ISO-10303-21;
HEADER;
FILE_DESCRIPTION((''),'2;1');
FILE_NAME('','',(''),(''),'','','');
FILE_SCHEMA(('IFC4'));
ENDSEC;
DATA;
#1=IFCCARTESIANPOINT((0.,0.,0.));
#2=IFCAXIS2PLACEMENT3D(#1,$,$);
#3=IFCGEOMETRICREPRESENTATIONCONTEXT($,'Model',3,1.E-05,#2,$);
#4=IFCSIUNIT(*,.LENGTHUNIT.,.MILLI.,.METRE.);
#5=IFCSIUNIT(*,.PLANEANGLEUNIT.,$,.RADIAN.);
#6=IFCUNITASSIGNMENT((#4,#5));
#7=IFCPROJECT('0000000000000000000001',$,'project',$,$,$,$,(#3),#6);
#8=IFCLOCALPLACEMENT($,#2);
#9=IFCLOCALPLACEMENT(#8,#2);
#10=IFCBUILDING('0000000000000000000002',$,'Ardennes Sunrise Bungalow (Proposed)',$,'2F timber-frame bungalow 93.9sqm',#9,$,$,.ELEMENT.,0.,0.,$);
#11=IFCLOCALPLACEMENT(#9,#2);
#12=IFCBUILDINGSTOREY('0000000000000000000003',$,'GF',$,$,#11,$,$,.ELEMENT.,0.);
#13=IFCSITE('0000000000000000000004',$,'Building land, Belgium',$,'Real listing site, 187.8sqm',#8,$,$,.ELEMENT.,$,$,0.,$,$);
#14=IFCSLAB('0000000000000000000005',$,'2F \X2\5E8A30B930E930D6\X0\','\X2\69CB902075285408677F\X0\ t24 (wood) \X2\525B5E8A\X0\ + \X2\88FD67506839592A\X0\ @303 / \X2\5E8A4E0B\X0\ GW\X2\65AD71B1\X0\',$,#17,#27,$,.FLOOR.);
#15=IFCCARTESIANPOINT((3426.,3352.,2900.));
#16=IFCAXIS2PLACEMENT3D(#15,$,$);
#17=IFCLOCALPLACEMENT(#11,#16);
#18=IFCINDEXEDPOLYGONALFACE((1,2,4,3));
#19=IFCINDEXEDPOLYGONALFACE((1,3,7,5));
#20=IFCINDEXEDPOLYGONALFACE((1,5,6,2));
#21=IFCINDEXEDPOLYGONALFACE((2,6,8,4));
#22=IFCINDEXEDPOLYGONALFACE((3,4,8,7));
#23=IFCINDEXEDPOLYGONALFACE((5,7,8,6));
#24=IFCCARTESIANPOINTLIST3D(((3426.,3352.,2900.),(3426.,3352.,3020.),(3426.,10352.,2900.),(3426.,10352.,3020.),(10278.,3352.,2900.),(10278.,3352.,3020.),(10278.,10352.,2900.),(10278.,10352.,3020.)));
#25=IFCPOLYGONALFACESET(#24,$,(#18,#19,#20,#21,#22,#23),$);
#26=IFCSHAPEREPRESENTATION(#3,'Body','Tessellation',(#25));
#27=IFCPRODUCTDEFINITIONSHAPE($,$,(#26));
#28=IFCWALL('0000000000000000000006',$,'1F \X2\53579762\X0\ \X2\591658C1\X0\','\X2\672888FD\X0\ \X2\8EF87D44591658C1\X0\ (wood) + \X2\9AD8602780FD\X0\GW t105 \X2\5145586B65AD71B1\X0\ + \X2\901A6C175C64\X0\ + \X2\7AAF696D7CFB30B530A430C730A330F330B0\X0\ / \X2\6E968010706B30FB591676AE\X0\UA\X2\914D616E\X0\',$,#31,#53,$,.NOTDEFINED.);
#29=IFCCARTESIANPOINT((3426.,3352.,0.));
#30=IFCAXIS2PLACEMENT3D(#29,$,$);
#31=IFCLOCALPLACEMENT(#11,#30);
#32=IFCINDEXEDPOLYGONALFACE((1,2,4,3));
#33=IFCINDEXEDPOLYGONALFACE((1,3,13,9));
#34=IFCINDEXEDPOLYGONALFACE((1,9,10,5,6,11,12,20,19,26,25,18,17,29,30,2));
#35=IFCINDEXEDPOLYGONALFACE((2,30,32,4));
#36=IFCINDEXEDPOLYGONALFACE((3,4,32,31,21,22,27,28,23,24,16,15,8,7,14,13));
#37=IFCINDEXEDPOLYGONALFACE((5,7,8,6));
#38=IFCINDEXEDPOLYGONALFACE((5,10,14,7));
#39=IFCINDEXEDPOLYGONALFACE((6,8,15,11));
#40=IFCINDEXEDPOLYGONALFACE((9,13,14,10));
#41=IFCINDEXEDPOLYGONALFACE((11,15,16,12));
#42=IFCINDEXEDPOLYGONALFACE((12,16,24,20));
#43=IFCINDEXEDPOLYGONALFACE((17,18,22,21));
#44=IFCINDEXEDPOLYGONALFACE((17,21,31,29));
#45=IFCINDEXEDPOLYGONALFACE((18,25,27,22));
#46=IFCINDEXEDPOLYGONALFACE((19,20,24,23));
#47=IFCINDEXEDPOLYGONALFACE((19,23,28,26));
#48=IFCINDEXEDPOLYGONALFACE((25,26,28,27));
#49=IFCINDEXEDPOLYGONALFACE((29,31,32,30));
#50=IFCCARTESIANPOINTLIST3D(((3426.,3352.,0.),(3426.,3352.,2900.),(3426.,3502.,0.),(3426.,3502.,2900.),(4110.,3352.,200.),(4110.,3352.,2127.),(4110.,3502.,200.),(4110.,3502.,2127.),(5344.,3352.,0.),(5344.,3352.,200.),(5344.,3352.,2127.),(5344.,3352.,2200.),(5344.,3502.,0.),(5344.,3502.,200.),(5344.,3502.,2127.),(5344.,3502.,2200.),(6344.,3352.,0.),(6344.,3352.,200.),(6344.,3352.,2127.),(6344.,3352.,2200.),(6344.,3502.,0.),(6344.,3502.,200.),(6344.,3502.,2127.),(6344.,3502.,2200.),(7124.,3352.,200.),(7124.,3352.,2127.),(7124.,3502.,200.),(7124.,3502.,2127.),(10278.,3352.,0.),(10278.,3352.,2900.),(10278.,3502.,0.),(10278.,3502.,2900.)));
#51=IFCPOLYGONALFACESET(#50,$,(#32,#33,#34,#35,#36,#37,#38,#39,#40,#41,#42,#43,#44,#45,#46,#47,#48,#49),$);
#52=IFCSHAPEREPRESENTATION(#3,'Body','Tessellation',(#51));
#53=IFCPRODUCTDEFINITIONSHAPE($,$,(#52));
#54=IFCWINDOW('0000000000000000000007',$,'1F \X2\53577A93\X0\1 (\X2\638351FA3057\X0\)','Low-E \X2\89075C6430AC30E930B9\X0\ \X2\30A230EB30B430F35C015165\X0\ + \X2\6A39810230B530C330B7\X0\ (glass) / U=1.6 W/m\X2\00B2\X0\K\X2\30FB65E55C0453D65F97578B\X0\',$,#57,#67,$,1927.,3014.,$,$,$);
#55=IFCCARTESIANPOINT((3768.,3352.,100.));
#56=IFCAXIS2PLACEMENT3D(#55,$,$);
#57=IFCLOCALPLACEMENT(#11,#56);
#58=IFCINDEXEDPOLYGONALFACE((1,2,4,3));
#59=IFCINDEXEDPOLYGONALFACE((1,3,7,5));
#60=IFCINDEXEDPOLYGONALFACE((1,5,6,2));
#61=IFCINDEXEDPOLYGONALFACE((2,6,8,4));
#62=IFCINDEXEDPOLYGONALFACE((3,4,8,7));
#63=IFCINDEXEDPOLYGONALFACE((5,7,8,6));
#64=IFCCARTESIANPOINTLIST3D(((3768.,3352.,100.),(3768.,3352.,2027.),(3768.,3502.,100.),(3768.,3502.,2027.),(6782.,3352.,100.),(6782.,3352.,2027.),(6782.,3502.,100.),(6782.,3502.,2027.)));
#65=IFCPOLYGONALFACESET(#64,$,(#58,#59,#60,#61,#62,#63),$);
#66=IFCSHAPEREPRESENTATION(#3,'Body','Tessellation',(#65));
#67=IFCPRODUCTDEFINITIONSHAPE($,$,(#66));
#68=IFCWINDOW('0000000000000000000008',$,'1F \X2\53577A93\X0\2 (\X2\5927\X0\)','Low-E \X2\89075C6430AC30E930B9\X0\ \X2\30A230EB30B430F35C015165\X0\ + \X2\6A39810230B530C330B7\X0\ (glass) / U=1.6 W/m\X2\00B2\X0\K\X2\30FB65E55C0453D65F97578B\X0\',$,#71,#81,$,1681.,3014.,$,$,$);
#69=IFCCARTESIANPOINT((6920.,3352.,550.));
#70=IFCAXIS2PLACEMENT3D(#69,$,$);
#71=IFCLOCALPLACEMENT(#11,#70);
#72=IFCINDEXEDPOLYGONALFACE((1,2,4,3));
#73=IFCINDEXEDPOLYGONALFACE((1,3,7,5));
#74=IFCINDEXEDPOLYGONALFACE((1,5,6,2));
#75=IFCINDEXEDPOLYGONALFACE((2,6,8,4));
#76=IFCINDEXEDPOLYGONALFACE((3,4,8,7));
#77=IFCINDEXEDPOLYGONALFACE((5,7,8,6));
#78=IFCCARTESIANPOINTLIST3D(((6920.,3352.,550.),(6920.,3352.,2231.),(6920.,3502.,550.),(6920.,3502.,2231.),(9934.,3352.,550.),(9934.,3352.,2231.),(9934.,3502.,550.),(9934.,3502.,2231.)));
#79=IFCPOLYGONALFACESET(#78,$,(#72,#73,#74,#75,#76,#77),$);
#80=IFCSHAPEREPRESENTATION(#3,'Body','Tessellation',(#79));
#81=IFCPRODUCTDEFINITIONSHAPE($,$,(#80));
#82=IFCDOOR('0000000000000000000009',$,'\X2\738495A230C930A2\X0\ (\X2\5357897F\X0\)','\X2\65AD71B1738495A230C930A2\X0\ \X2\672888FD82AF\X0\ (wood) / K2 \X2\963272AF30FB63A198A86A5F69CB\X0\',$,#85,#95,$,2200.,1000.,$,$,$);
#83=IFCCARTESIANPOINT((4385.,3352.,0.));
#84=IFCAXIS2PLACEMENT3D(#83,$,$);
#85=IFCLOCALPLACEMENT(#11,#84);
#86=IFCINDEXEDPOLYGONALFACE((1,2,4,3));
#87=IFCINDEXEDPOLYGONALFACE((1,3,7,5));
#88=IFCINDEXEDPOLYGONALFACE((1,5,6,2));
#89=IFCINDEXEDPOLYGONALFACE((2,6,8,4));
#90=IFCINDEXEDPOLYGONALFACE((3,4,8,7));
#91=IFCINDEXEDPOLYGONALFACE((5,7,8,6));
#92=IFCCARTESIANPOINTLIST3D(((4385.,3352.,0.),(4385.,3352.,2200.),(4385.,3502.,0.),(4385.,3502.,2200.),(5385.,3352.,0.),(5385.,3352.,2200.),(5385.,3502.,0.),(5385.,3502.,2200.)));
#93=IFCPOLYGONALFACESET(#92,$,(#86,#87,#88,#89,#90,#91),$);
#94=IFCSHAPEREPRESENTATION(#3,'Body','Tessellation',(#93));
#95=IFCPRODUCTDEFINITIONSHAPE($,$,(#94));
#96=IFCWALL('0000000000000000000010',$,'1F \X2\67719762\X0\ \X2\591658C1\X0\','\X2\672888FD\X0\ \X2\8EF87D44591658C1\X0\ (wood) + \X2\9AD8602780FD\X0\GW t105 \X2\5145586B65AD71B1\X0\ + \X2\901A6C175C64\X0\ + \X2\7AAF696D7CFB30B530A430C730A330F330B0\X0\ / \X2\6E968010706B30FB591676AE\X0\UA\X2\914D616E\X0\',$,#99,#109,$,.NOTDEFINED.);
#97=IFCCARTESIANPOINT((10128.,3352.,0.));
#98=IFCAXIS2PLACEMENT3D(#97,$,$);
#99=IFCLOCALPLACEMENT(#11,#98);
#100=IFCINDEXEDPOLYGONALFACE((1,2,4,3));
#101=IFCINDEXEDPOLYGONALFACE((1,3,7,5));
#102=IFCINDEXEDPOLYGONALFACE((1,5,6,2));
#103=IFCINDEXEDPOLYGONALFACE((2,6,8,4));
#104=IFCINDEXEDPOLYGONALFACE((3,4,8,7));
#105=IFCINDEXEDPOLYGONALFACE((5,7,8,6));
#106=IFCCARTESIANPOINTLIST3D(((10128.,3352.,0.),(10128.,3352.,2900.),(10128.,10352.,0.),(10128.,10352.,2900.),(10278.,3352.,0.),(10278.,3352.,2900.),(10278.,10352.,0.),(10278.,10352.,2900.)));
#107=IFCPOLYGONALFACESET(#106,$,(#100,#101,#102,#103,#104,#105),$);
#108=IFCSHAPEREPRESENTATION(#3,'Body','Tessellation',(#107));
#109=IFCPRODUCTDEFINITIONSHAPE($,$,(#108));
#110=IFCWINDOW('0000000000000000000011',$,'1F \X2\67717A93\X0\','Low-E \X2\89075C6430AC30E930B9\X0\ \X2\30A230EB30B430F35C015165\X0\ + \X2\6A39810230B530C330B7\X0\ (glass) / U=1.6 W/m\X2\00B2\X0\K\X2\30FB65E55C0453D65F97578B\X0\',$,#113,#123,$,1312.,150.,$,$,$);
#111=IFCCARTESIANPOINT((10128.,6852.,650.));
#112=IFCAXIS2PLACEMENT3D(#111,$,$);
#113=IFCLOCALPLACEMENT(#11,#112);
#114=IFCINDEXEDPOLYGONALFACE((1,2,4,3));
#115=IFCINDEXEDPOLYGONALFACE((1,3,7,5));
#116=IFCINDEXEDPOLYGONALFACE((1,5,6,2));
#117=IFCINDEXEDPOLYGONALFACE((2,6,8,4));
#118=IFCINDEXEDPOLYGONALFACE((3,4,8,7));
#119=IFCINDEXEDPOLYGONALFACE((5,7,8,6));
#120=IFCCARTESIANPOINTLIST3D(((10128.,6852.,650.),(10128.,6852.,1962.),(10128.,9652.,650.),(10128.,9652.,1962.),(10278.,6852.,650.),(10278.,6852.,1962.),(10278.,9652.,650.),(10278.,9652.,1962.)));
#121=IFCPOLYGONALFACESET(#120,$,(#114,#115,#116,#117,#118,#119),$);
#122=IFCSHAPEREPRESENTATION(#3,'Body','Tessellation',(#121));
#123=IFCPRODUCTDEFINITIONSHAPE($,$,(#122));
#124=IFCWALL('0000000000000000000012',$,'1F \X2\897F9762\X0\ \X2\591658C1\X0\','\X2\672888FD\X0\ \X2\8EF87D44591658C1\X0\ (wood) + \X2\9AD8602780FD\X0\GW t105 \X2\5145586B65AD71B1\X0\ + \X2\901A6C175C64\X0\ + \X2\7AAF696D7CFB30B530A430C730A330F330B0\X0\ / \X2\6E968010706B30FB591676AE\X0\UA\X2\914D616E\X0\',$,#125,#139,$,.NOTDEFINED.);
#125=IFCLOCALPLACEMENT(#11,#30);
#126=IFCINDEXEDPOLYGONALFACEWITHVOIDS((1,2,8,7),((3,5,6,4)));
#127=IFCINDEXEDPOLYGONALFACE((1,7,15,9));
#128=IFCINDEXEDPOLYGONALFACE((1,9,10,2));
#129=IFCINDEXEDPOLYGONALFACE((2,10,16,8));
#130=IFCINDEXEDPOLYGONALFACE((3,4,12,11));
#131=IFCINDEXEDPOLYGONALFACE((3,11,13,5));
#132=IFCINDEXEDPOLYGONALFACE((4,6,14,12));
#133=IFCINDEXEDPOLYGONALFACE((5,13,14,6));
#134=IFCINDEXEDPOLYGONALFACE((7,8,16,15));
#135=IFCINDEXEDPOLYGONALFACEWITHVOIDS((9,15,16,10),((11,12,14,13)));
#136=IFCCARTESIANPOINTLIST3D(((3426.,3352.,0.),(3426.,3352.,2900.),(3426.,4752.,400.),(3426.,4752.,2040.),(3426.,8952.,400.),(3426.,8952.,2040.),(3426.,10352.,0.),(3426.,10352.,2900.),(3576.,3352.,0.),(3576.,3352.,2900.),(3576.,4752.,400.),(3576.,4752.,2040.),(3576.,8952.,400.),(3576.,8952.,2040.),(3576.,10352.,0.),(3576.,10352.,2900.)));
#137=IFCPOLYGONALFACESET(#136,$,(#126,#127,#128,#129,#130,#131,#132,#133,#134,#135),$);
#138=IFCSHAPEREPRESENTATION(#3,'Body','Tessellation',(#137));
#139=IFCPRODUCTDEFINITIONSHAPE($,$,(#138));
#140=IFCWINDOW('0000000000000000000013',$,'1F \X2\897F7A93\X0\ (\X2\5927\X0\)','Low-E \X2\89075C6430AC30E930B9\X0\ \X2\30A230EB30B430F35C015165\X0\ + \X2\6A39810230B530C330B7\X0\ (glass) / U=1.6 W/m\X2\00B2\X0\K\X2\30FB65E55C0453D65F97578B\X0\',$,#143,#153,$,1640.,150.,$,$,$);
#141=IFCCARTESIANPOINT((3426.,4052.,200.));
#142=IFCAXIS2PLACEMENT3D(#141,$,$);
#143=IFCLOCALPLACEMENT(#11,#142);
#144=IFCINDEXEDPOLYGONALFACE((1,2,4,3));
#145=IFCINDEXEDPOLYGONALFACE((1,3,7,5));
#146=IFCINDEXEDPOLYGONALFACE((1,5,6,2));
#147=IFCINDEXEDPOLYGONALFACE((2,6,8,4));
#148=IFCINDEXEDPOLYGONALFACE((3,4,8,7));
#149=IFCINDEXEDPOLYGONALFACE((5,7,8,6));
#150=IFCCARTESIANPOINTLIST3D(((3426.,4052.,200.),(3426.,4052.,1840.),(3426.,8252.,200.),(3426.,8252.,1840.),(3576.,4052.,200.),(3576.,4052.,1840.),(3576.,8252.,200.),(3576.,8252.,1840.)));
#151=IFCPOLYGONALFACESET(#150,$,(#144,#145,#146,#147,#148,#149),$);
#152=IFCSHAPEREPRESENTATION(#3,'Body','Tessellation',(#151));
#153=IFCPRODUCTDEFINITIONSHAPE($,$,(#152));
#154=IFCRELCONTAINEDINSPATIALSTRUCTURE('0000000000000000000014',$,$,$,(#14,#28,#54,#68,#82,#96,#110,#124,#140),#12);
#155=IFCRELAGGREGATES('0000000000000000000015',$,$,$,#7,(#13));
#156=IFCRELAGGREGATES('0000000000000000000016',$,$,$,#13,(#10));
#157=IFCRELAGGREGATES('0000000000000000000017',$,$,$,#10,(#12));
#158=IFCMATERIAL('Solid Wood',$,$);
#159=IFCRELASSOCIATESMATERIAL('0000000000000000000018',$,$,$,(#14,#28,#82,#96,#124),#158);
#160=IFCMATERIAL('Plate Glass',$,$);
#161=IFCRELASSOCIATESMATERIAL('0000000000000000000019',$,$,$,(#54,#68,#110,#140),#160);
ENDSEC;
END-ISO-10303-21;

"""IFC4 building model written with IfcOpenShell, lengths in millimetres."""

from ifc_helpers import new_model, si_unit, frame, frame_2d, origin, place, context, project, spatial, rectangle, extrude, material, element, fill, save


model = new_model("IFC4")

# Units and contexts
model_context = context("Model", 3, precision=1e-05, world=origin())
ifc_project = project(units=[si_unit("LENGTHUNIT", "METRE", prefix="MILLI"), si_unit("PLANEANGLEUNIT", "RADIAN")], contexts=[model_context])

# Site, building, storey
site_placement = place(None, origin())
site = spatial("IfcSite", under=ifc_project, at=site_placement, Name="Building land, Belgium", ObjectType="Real listing site, 187.8sqm", CompositionType="ELEMENT", RefElevation=0.0)
building_placement = place(site_placement, origin())
building = spatial("IfcBuilding", under=site, at=building_placement, Name="Ardennes Sunrise Bungalow (Proposed)", ObjectType="2F timber-frame bungalow 93.9sqm", CompositionType="ELEMENT", ElevationOfRefHeight=0.0, ElevationOfTerrain=0.0)
storey_placement = place(building_placement, origin())
storey = spatial("IfcBuildingStorey", under=building, at=storey_placement, Name="GF", CompositionType="ELEMENT", Elevation=0.0)

# Slab
ifc_material_1 = material(Name="Solid Wood")
slab_1_placement = place(storey_placement, frame((3426.0, 3352.0, 2900.0)))
element("IfcSlab", 1, at=slab_1_placement, inside=storey, material=ifc_material_1, Name="2F 床スラブ", Description="構造用合板 t24 (wood) 剛床 + 製材根太 @303 / 床下 GW断熱", PredefinedType="FLOOR", context=model_context, shape_type="SweptSolid", body=[
    extrude(rectangle(XDim=6852.0, YDim=7000.0, at=frame_2d((3426.0, 3500.0))), frame((3426.0, 3352.0, 2900.0)), (0.0, 0.0, 1.0), 120.0),
])

# Wall, openings, windows, door
wall_1_placement = place(storey_placement, frame((3426.0, 3352.0, 0.0)))
wall_1 = element("IfcWall", 2, at=wall_1_placement, inside=storey, material=ifc_material_1, Name="1F 南面 外壁", Description="木製 軸組外壁 (wood) + 高性能GW t105 充填断熱 + 通気層 + 窯業系サイディング / 準耐火・外皮UA配慮", PredefinedType="NOTDEFINED", context=model_context, shape_type="SweptSolid", body=[
    extrude(rectangle(XDim=6852.0, YDim=150.0, at=frame_2d((3426.0, 75.0))), frame((3426.0, 3352.0, 0.0)), (0.0, 0.0, 1.0), 2900.0),
])
opening_1_placement = place(storey_placement, frame((3768.0, 3352.0, 100.0)))
opening_1 = element("IfcOpeningElement", 3, at=opening_1_placement, cuts=wall_1, PredefinedType="NOTDEFINED", context=model_context, shape_type="SweptSolid", body=[
    extrude(rectangle(XDim=3014.0, YDim=150.0, at=frame_2d((1507.0, 75.0))), frame((3768.0, 3352.0, 100.0)), (0.0, 0.0, 1.0), 1927.0),
])
opening_2_placement = place(storey_placement, frame((6920.0, 3352.0, 550.0)))
opening_2 = element("IfcOpeningElement", 4, at=opening_2_placement, cuts=wall_1, PredefinedType="NOTDEFINED", context=model_context, shape_type="SweptSolid", body=[
    extrude(rectangle(XDim=3014.0, YDim=150.0, at=frame_2d((1507.0, 75.0))), frame((6920.0, 3352.0, 550.0)), (0.0, 0.0, 1.0), 1681.0),
])
opening_3_placement = place(storey_placement, frame((4385.0, 3352.0, 0.0)))
opening_3 = element("IfcOpeningElement", 5, at=opening_3_placement, cuts=wall_1, PredefinedType="NOTDEFINED", context=model_context, shape_type="SweptSolid", body=[
    extrude(rectangle(XDim=1000.0, YDim=150.0, at=frame_2d((500.0, 75.0))), frame((4385.0, 3352.0, 0.0)), (0.0, 0.0, 1.0), 2200.0),
])
ifc_material_2 = material(Name="Plate Glass")
window_1_placement = place(storey_placement, frame((3768.0, 3352.0, 100.0)))
window_1 = element("IfcWindow", 6, at=window_1_placement, inside=storey, material=ifc_material_2, Name="1F 南窓1 (掃出し)", Description="Low-E 複層ガラス アルゴン封入 + 樹脂サッシ (glass) / U=1.6 W/m²K・日射取得型", OverallHeight=1927.0, OverallWidth=3014.0, context=model_context, shape_type="SweptSolid", body=[
    extrude(rectangle(XDim=3014.0, YDim=150.0, at=frame_2d((1507.0, 75.0))), frame((3768.0, 3352.0, 100.0)), (0.0, 0.0, 1.0), 1927.0),
])
fill(opening_1, window_1)
window_2_placement = place(storey_placement, frame((6920.0, 3352.0, 550.0)))
window_2 = element("IfcWindow", 7, at=window_2_placement, inside=storey, material=ifc_material_2, Name="1F 南窓2 (大)", Description="Low-E 複層ガラス アルゴン封入 + 樹脂サッシ (glass) / U=1.6 W/m²K・日射取得型", OverallHeight=1681.0, OverallWidth=3014.0, context=model_context, shape_type="SweptSolid", body=[
    extrude(rectangle(XDim=3014.0, YDim=150.0, at=frame_2d((1507.0, 75.0))), frame((6920.0, 3352.0, 550.0)), (0.0, 0.0, 1.0), 1681.0),
])
fill(opening_2, window_2)
door_placement = place(storey_placement, frame((4385.0, 3352.0, 0.0)))
door = element("IfcDoor", 8, at=door_placement, inside=storey, material=ifc_material_1, Name="玄関ドア (南西)", Description="断熱玄関ドア 木製芯 (wood) / K2 防犯・採風機構", OverallHeight=2200.0, OverallWidth=1000.0, context=model_context, shape_type="SweptSolid", body=[
    extrude(rectangle(XDim=1000.0, YDim=150.0, at=frame_2d((500.0, 75.0))), frame((4385.0, 3352.0, 0.0)), (0.0, 0.0, 1.0), 2200.0),
])
fill(opening_3, door)

# Walls, openings, windows
wall_2_placement = place(storey_placement, frame((10128.0, 3352.0, 0.0)))
wall_2 = element("IfcWall", 9, at=wall_2_placement, inside=storey, material=ifc_material_1, Name="1F 東面 外壁", Description="木製 軸組外壁 (wood) + 高性能GW t105 充填断熱 + 通気層 + 窯業系サイディング / 準耐火・外皮UA配慮", PredefinedType="NOTDEFINED", context=model_context, shape_type="SweptSolid", body=[
    extrude(rectangle(XDim=150.0, YDim=7000.0, at=frame_2d((75.0, 3500.0))), frame((10128.0, 3352.0, 0.0)), (0.0, 0.0, 1.0), 2900.0),
])
opening_4_placement = place(storey_placement, frame((10128.0, 6852.0, 650.0)))
opening_4 = element("IfcOpeningElement", 10, at=opening_4_placement, cuts=wall_2, PredefinedType="NOTDEFINED", context=model_context, shape_type="SweptSolid", body=[
    extrude(rectangle(XDim=150.0, YDim=2800.0, at=frame_2d((75.0, 1400.0))), frame((10128.0, 6852.0, 650.0)), (0.0, 0.0, 1.0), 1312.0),
])
window_3_placement = place(storey_placement, frame((10128.0, 6852.0, 650.0)))
window_3 = element("IfcWindow", 11, at=window_3_placement, inside=storey, material=ifc_material_2, Name="1F 東窓", Description="Low-E 複層ガラス アルゴン封入 + 樹脂サッシ (glass) / U=1.6 W/m²K・日射取得型", OverallHeight=1312.0, OverallWidth=150.0, context=model_context, shape_type="SweptSolid", body=[
    extrude(rectangle(XDim=150.0, YDim=2800.0, at=frame_2d((75.0, 1400.0))), frame((10128.0, 6852.0, 650.0)), (0.0, 0.0, 1.0), 1312.0),
])
fill(opening_4, window_3)
wall_3_placement = place(storey_placement, frame((3426.0, 3352.0, 0.0)))
wall_3 = element("IfcWall", 12, at=wall_3_placement, inside=storey, material=ifc_material_1, Name="1F 西面 外壁", Description="木製 軸組外壁 (wood) + 高性能GW t105 充填断熱 + 通気層 + 窯業系サイディング / 準耐火・外皮UA配慮", PredefinedType="NOTDEFINED", context=model_context, shape_type="SweptSolid", body=[
    extrude(rectangle(XDim=150.0, YDim=7000.0, at=frame_2d((75.0, 3500.0))), frame((3426.0, 3352.0, 0.0)), (0.0, 0.0, 1.0), 2900.0),
])
opening_5_placement = place(storey_placement, frame((3426.0, 4052.0, 200.0)))
opening_5 = element("IfcOpeningElement", 13, at=opening_5_placement, cuts=wall_3, PredefinedType="NOTDEFINED", context=model_context, shape_type="SweptSolid", body=[
    extrude(rectangle(XDim=150.0, YDim=4200.0, at=frame_2d((75.0, 2100.0))), frame((3426.0, 4052.0, 200.0)), (0.0, 0.0, 1.0), 1640.0),
])
window_4_placement = place(storey_placement, frame((3426.0, 4052.0, 200.0)))
window_4 = element("IfcWindow", 14, at=window_4_placement, inside=storey, material=ifc_material_2, Name="1F 西窓 (大)", Description="Low-E 複層ガラス アルゴン封入 + 樹脂サッシ (glass) / U=1.6 W/m²K・日射取得型", OverallHeight=1640.0, OverallWidth=150.0, context=model_context, shape_type="SweptSolid", body=[
    extrude(rectangle(XDim=150.0, YDim=4200.0, at=frame_2d((75.0, 2100.0))), frame((3426.0, 4052.0, 200.0)), (0.0, 0.0, 1.0), 1640.0),
])
fill(opening_5, window_4)

save(model, "model.ifc")
